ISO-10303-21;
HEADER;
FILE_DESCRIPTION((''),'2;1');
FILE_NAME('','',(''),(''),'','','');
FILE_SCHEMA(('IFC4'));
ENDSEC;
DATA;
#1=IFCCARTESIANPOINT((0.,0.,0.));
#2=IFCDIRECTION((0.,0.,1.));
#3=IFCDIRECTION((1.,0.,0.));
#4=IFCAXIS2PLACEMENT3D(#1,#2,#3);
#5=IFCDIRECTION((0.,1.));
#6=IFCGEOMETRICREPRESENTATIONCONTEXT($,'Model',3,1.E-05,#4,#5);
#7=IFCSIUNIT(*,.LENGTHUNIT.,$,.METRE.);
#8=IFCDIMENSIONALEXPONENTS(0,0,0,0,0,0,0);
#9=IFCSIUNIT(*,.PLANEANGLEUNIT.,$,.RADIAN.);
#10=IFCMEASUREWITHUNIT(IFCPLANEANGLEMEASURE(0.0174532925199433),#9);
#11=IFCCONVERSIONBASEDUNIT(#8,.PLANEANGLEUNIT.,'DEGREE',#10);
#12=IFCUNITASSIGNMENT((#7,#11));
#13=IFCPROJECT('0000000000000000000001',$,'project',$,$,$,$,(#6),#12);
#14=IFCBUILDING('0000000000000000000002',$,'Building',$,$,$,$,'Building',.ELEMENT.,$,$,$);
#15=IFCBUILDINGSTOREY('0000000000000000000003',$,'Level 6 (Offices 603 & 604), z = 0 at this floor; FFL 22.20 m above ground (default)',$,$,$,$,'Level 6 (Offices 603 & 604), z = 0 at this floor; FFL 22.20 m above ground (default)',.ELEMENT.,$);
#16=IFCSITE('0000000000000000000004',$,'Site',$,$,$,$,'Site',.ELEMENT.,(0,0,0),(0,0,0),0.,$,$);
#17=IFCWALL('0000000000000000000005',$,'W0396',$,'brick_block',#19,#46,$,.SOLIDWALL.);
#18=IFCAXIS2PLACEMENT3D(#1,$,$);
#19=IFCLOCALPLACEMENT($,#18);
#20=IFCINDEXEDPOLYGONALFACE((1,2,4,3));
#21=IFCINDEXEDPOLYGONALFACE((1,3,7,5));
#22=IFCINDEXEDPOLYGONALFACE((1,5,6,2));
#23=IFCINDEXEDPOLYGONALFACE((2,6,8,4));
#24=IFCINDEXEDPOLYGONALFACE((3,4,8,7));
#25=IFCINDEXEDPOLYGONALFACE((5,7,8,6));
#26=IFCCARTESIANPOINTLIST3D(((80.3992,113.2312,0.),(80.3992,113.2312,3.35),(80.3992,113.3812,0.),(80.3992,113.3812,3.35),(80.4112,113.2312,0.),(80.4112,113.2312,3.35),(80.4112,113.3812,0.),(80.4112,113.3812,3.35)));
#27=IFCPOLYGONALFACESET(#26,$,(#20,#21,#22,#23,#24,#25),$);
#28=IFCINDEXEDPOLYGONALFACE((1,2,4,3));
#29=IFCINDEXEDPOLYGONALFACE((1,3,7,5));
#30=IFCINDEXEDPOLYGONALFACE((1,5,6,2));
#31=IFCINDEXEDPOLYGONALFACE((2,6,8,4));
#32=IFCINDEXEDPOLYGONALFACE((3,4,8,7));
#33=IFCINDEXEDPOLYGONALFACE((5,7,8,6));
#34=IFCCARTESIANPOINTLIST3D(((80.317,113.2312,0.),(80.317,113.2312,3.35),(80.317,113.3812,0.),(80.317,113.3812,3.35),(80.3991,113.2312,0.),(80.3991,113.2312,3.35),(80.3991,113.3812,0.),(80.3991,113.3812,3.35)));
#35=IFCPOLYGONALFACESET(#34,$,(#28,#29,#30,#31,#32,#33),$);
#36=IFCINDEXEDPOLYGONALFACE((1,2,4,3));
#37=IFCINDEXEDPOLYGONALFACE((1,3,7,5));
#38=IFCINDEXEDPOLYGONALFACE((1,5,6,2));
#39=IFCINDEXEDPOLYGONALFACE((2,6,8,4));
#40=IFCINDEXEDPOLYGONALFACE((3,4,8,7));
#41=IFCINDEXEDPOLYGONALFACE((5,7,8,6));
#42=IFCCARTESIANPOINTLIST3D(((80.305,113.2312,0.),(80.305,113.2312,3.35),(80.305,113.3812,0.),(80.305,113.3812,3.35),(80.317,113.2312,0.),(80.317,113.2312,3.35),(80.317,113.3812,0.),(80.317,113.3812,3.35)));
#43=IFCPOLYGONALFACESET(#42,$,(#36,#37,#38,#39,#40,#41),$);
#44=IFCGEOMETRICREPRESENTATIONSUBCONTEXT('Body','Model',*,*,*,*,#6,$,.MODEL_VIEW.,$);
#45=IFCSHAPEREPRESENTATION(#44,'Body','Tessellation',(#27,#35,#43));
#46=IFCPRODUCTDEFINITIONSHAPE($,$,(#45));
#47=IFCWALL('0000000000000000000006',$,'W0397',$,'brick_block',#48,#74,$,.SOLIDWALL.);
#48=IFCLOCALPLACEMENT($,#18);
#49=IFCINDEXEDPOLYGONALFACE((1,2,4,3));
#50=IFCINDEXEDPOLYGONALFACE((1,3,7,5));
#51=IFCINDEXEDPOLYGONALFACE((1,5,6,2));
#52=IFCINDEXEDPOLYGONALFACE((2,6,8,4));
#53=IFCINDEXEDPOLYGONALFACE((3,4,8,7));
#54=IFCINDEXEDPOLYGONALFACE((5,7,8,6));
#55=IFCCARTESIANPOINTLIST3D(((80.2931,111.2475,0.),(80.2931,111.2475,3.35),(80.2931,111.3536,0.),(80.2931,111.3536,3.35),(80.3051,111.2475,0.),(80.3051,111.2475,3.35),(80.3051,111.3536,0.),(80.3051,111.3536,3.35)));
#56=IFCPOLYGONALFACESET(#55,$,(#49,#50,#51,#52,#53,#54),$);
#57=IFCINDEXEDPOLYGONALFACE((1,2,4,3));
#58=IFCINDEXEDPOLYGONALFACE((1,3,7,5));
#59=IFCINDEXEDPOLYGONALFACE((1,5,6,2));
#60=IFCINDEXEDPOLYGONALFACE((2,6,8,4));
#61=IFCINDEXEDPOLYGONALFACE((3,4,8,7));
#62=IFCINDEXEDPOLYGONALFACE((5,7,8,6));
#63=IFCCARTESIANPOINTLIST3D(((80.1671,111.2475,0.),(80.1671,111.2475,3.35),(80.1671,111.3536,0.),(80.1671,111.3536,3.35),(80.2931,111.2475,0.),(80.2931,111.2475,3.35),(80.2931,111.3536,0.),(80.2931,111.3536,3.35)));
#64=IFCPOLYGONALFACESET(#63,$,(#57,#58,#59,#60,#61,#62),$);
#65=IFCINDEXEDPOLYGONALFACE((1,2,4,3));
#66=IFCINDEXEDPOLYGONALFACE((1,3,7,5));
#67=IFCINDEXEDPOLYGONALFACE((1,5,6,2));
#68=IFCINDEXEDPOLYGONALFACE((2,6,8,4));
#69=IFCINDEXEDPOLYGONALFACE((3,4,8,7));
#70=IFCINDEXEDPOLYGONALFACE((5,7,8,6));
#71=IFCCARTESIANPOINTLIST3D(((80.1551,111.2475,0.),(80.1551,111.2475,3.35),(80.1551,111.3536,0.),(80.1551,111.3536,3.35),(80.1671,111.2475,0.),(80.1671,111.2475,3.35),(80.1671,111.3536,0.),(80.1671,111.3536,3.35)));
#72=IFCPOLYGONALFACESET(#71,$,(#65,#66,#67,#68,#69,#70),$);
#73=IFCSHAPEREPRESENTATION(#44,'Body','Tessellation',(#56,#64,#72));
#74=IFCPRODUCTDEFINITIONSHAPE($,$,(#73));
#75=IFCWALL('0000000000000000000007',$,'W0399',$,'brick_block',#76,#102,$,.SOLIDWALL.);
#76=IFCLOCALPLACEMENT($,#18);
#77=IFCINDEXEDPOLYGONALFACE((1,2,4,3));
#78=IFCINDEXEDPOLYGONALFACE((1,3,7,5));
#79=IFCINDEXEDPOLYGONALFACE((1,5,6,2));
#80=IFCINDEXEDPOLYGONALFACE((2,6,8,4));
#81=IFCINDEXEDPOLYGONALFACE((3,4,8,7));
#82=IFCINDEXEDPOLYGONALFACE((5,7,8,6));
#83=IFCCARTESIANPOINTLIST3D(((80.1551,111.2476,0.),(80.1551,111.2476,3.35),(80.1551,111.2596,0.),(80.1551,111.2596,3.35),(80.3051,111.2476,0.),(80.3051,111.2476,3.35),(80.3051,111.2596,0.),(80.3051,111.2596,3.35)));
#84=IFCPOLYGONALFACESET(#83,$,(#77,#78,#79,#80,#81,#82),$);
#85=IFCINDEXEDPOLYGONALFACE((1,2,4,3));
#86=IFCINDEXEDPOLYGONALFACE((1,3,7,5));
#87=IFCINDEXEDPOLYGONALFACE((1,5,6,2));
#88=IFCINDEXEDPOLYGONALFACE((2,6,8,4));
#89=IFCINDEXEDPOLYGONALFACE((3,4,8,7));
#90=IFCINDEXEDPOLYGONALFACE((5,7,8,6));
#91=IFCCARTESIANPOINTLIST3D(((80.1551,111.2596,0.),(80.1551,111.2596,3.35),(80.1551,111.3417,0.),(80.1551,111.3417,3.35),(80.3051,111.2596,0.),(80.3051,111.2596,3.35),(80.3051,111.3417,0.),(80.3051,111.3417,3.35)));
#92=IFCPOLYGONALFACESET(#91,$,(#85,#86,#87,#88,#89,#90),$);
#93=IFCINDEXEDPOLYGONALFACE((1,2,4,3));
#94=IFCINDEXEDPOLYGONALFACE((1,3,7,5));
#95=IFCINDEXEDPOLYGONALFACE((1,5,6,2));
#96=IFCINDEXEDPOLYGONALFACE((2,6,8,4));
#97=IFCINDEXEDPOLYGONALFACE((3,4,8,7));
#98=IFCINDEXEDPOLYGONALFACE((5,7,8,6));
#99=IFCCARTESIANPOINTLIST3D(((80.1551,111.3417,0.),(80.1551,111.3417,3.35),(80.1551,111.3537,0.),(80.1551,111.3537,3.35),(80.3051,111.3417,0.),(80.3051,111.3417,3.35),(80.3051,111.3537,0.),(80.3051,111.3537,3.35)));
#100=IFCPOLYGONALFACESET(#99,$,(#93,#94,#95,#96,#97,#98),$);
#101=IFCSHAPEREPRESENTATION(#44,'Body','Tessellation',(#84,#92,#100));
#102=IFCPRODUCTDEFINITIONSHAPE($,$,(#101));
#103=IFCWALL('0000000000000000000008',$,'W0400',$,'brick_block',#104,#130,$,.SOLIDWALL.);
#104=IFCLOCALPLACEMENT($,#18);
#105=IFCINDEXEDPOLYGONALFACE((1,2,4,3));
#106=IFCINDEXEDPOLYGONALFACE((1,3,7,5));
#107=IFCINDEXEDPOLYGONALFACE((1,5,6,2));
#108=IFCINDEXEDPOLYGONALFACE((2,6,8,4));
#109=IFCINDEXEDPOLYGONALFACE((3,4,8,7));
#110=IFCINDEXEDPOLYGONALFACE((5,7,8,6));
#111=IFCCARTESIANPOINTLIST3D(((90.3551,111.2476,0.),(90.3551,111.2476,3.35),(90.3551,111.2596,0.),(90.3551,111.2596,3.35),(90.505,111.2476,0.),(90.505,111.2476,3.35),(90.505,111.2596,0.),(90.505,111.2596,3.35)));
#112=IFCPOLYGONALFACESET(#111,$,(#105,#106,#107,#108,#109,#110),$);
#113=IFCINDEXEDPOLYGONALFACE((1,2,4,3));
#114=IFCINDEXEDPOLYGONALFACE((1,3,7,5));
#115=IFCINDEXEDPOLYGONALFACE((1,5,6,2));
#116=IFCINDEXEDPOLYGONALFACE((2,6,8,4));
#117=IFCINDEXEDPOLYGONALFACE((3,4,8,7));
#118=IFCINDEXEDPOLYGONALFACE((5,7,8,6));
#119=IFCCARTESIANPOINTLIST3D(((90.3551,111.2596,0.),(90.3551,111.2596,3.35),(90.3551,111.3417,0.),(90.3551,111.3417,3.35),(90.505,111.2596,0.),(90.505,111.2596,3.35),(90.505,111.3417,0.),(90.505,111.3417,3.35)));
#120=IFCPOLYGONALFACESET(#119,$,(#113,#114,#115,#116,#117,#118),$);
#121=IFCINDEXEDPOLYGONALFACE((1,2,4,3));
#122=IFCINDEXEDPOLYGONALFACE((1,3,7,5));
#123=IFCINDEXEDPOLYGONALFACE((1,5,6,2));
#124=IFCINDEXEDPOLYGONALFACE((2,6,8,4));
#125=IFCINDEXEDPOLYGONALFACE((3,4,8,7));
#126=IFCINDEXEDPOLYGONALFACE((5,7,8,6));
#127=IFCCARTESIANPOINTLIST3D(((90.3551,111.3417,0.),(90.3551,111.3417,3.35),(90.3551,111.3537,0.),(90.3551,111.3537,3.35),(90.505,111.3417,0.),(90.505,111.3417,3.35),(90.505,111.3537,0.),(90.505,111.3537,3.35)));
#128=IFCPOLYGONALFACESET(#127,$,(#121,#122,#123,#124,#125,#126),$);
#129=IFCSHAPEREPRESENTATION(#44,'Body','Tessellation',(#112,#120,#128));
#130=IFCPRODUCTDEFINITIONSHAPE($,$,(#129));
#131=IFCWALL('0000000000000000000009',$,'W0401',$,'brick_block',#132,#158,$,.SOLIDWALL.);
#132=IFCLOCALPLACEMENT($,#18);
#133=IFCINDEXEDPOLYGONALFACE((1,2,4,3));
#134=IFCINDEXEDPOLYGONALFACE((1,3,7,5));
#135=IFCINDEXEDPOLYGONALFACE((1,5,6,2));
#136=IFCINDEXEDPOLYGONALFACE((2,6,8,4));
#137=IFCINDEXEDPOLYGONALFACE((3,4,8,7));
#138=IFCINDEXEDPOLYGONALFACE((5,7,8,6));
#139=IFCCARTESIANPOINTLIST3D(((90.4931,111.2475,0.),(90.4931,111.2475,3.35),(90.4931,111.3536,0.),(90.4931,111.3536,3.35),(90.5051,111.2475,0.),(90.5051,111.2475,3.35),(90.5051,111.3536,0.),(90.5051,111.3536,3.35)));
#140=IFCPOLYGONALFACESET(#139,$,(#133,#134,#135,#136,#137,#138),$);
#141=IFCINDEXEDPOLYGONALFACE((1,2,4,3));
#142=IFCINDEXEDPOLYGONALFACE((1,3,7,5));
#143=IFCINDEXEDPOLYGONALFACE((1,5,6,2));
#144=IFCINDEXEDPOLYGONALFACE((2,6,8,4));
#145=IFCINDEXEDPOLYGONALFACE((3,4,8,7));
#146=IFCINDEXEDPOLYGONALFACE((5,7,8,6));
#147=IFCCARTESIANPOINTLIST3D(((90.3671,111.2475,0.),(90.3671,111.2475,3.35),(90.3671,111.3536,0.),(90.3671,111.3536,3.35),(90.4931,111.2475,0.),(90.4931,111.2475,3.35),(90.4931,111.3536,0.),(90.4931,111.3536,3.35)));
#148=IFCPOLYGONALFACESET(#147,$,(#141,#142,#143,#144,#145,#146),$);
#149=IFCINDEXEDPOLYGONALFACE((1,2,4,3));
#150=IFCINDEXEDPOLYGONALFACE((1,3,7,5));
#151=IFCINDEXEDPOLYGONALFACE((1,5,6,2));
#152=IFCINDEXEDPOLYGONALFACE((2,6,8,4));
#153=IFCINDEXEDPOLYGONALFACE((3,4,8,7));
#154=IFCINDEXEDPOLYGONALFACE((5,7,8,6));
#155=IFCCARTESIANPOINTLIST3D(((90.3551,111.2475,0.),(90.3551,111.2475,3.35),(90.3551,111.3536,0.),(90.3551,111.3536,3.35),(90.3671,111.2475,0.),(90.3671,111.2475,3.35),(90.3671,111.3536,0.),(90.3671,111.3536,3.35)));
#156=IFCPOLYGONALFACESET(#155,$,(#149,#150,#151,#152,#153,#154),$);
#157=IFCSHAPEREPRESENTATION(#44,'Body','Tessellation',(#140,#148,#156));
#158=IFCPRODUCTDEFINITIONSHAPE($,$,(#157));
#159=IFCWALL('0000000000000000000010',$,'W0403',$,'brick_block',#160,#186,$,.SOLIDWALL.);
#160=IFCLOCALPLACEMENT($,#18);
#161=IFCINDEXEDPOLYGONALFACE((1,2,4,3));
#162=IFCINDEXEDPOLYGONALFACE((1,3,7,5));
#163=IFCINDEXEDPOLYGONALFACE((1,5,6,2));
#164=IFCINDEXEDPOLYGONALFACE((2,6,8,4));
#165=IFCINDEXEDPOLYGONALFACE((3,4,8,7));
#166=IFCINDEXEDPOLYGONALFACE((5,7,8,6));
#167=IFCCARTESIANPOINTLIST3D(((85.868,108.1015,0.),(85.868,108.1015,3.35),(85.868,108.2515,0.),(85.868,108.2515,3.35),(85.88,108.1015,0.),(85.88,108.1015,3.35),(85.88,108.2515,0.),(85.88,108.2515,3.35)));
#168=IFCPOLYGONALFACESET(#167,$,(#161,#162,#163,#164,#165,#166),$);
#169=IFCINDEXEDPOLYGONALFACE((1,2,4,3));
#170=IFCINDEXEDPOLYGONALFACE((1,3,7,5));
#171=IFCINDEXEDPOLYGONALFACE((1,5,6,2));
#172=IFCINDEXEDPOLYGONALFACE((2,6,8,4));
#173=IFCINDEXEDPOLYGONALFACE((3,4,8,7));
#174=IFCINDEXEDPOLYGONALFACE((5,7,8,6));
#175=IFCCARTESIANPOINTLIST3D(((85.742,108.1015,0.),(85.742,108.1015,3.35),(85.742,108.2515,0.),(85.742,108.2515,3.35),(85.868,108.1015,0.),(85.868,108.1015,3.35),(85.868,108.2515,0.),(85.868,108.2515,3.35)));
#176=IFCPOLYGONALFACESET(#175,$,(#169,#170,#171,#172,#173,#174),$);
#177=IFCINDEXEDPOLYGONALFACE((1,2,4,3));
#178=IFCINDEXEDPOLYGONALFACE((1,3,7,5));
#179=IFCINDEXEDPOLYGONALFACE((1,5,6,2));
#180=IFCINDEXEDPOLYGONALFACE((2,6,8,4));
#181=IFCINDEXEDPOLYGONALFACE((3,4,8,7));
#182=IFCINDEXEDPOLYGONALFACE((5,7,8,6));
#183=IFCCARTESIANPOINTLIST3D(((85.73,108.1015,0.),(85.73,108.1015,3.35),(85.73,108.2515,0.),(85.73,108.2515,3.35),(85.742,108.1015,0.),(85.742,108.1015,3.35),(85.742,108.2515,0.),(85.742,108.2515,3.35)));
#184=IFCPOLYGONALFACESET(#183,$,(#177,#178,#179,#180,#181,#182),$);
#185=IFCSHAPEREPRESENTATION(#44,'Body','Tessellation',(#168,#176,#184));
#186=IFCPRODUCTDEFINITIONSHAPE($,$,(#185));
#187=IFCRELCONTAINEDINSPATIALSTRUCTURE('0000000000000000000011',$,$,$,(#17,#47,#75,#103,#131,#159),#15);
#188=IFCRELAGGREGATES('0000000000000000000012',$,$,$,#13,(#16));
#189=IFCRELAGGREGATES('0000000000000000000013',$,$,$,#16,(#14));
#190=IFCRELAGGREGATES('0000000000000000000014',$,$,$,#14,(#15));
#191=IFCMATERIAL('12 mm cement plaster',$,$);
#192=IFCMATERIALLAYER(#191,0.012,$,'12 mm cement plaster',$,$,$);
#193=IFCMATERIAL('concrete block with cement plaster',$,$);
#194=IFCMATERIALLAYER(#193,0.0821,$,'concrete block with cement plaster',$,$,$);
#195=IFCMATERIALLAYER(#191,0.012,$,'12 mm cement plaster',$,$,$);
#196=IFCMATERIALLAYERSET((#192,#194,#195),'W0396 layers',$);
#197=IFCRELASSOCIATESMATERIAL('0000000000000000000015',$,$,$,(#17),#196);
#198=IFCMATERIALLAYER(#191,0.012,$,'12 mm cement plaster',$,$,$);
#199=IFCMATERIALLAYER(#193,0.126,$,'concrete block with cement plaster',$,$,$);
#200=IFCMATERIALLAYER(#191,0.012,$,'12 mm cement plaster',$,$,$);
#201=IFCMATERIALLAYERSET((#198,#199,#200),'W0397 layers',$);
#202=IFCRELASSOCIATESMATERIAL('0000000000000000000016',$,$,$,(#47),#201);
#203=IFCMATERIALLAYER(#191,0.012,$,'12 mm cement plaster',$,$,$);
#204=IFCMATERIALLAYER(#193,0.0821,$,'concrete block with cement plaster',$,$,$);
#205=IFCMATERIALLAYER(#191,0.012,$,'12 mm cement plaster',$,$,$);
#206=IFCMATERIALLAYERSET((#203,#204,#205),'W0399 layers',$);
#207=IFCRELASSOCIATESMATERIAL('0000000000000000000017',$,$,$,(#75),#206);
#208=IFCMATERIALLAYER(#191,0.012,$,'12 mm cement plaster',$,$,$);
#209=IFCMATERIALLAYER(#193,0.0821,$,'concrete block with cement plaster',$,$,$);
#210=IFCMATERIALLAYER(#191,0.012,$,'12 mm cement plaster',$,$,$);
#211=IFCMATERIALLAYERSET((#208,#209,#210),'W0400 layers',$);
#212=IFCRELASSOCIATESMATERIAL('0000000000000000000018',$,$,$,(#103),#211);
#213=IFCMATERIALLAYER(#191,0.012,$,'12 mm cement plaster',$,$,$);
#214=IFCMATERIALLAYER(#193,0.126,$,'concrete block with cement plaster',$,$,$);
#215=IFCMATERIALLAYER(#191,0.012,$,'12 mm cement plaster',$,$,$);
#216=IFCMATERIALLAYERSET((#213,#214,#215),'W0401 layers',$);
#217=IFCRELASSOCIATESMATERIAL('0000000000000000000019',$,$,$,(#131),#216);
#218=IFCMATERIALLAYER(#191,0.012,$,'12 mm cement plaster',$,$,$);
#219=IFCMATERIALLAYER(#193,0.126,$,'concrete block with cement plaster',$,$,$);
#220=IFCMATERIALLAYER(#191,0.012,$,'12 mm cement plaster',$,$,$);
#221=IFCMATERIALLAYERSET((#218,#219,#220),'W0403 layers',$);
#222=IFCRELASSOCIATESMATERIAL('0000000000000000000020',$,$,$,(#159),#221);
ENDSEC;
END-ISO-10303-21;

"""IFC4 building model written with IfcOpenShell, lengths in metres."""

from ifc_helpers import new_model, entity, si_unit, converted_unit, direction, frame, frame_2d, origin_with_axes, place, context, subcontext, project, spatial, rectangle, extrude, material, layer, layer_set, layer_usage, element, save


model = new_model("IFC4")

# Units and contexts
model_context = context("Model", 3, precision=1e-05, world=origin_with_axes(), true_north=direction((0.0, 1.0)))
body_context = subcontext(model_context, "Body", "Model", "MODEL_VIEW")
ifc_project = project(units=[si_unit("LENGTHUNIT", "METRE"), converted_unit("PLANEANGLEUNIT", "DEGREE", entity("IfcPlaneAngleMeasure", 0.0174532925199433), si_unit("PLANEANGLEUNIT", "RADIAN"), dimensions=[0, 0, 0, 0, 0, 0, 0])], contexts=[model_context])

# Site, building, storey
site = spatial("IfcSite", under=ifc_project, Name="Site", LongName="Site", CompositionType="ELEMENT", RefLatitude=(0, 0, 0), RefLongitude=(0, 0, 0), RefElevation=0.0)
building = spatial("IfcBuilding", under=site, Name="Building", LongName="Building", CompositionType="ELEMENT")
storey = spatial("IfcBuildingStorey", under=building, Name="Level 6 (Offices 603 & 604), z = 0 at this floor; FFL 22.20 m above ground (default)", LongName="Level 6 (Offices 603 & 604), z = 0 at this floor; FFL 22.20 m above ground (default)", CompositionType="ELEMENT")

# Shared definitions
placement = place(None, origin_with_axes())

# Walls
ifc_material_1 = material(Name="12 mm cement plaster")
ifc_material_2 = material(Name="concrete block with cement plaster")
ifc_layer_1 = layer(ifc_material_1, 0.012, Name="12 mm cement plaster")
ifc_layer_2 = layer(ifc_material_2, 0.0821, Name="concrete block with cement plaster")
ifc_layer_3 = layer(ifc_material_1, 0.012, Name="12 mm cement plaster")
ifc_layer_set_1 = layer_set([ifc_layer_1, ifc_layer_2, ifc_layer_3], Name="W0396 layers")
ifc_layer_usage_1 = layer_usage(ifc_layer_set_1, "AXIS2", "POSITIVE", -0.053)
element("IfcWall", 1, at=placement, inside=storey, material=ifc_layer_usage_1, Name="W0396", ObjectType="brick_block", PredefinedType="SOLIDWALL", context=body_context, shape_type="SweptSolid", body=[
    extrude(rectangle(XDim=0.15, YDim=0.012, at=frame_2d((0.0, 0.0), x_axis=(0.0, 1.0))), frame((80.4052, 113.3062, 0.0), z_axis=(0.0, 0.0, 1.0), x_axis=(1.0, 0.0, 0.0)), (0.0, 0.0, 1.0), 3.35),
    extrude(rectangle(XDim=0.15, YDim=0.0821, at=frame_2d((-0.0471, 0.0), x_axis=(0.0, 1.0))), frame((80.4052, 113.3062, 0.0), z_axis=(0.0, 0.0, 1.0), x_axis=(1.0, 0.0, 0.0)), (0.0, 0.0, 1.0), 3.35),
    extrude(rectangle(XDim=0.15, YDim=0.012, at=frame_2d((-0.0941, 0.0), x_axis=(0.0, 1.0))), frame((80.4052, 113.3062, 0.0), z_axis=(0.0, 0.0, 1.0), x_axis=(1.0, 0.0, 0.0)), (0.0, 0.0, 1.0), 3.35),
])
ifc_layer_4 = layer(ifc_material_1, 0.012, Name="12 mm cement plaster")
ifc_layer_5 = layer(ifc_material_2, 0.126, Name="concrete block with cement plaster")
ifc_layer_6 = layer(ifc_material_1, 0.012, Name="12 mm cement plaster")
ifc_layer_set_2 = layer_set([ifc_layer_4, ifc_layer_5, ifc_layer_6], Name="W0397 layers")
ifc_layer_usage_2 = layer_usage(ifc_layer_set_2, "AXIS2", "POSITIVE", -0.075)
element("IfcWall", 2, at=placement, inside=storey, material=ifc_layer_usage_2, Name="W0397", ObjectType="brick_block", PredefinedType="SOLIDWALL", context=body_context, shape_type="SweptSolid", body=[
    extrude(rectangle(XDim=0.1061, YDim=0.012, at=frame_2d((0.0, 0.0), x_axis=(0.0, 1.0))), frame((80.2991, 111.3006, 0.0), z_axis=(0.0, 0.0, 1.0), x_axis=(1.0, 0.0, 0.0)), (0.0, 0.0, 1.0), 3.35),
    extrude(rectangle(XDim=0.1061, YDim=0.126, at=frame_2d((-0.069, 0.0), x_axis=(0.0, 1.0))), frame((80.2991, 111.3006, 0.0), z_axis=(0.0, 0.0, 1.0), x_axis=(1.0, 0.0, 0.0)), (0.0, 0.0, 1.0), 3.35),
    extrude(rectangle(XDim=0.1061, YDim=0.012, at=frame_2d((-0.138, 0.0), x_axis=(0.0, 1.0))), frame((80.2991, 111.3006, 0.0), z_axis=(0.0, 0.0, 1.0), x_axis=(1.0, 0.0, 0.0)), (0.0, 0.0, 1.0), 3.35),
])
ifc_layer_7 = layer(ifc_material_1, 0.012, Name="12 mm cement plaster")
ifc_layer_8 = layer(ifc_material_2, 0.0821, Name="concrete block with cement plaster")
ifc_layer_9 = layer(ifc_material_1, 0.012, Name="12 mm cement plaster")
ifc_layer_set_3 = layer_set([ifc_layer_7, ifc_layer_8, ifc_layer_9], Name="W0399 layers")
ifc_layer_usage_3 = layer_usage(ifc_layer_set_3, "AXIS2", "POSITIVE", -0.053)
element("IfcWall", 3, at=placement, inside=storey, material=ifc_layer_usage_3, Name="W0399", ObjectType="brick_block", PredefinedType="SOLIDWALL", context=body_context, shape_type="SweptSolid", body=[
    extrude(rectangle(XDim=0.15, YDim=0.012, at=frame_2d((0.0, 0.0), x_axis=(1.0, 0.0))), frame((80.2301, 111.2536, 0.0), z_axis=(0.0, 0.0, 1.0), x_axis=(1.0, 0.0, 0.0)), (0.0, 0.0, 1.0), 3.35),
    extrude(rectangle(XDim=0.15, YDim=0.0821, at=frame_2d((0.0, 0.0471), x_axis=(1.0, 0.0))), frame((80.2301, 111.2536, 0.0), z_axis=(0.0, 0.0, 1.0), x_axis=(1.0, 0.0, 0.0)), (0.0, 0.0, 1.0), 3.35),
    extrude(rectangle(XDim=0.15, YDim=0.012, at=frame_2d((0.0, 0.0941), x_axis=(1.0, 0.0))), frame((80.2301, 111.2536, 0.0), z_axis=(0.0, 0.0, 1.0), x_axis=(1.0, 0.0, 0.0)), (0.0, 0.0, 1.0), 3.35),
])
ifc_layer_10 = layer(ifc_material_1, 0.012, Name="12 mm cement plaster")
ifc_layer_11 = layer(ifc_material_2, 0.0821, Name="concrete block with cement plaster")
ifc_layer_12 = layer(ifc_material_1, 0.012, Name="12 mm cement plaster")
ifc_layer_set_4 = layer_set([ifc_layer_10, ifc_layer_11, ifc_layer_12], Name="W0400 layers")
ifc_layer_usage_4 = layer_usage(ifc_layer_set_4, "AXIS2", "POSITIVE", -0.053)
element("IfcWall", 4, at=placement, inside=storey, material=ifc_layer_usage_4, Name="W0400", ObjectType="brick_block", PredefinedType="SOLIDWALL", context=body_context, shape_type="SweptSolid", body=[
    extrude(rectangle(XDim=0.1499, YDim=0.012, at=frame_2d((0.0, 0.0), x_axis=(1.0, 0.0))), frame((90.43, 111.2536, 0.0), z_axis=(0.0, 0.0, 1.0), x_axis=(1.0, 0.0, 0.0)), (0.0, 0.0, 1.0), 3.35),
    extrude(rectangle(XDim=0.1499, YDim=0.0821, at=frame_2d((0.0, 0.0471), x_axis=(1.0, 0.0))), frame((90.43, 111.2536, 0.0), z_axis=(0.0, 0.0, 1.0), x_axis=(1.0, 0.0, 0.0)), (0.0, 0.0, 1.0), 3.35),
    extrude(rectangle(XDim=0.1499, YDim=0.012, at=frame_2d((0.0, 0.0941), x_axis=(1.0, 0.0))), frame((90.43, 111.2536, 0.0), z_axis=(0.0, 0.0, 1.0), x_axis=(1.0, 0.0, 0.0)), (0.0, 0.0, 1.0), 3.35),
])
ifc_layer_13 = layer(ifc_material_1, 0.012, Name="12 mm cement plaster")
ifc_layer_14 = layer(ifc_material_2, 0.126, Name="concrete block with cement plaster")
ifc_layer_15 = layer(ifc_material_1, 0.012, Name="12 mm cement plaster")
ifc_layer_set_5 = layer_set([ifc_layer_13, ifc_layer_14, ifc_layer_15], Name="W0401 layers")
ifc_layer_usage_5 = layer_usage(ifc_layer_set_5, "AXIS2", "POSITIVE", -0.075)
element("IfcWall", 5, at=placement, inside=storey, material=ifc_layer_usage_5, Name="W0401", ObjectType="brick_block", PredefinedType="SOLIDWALL", context=body_context, shape_type="SweptSolid", body=[
    extrude(rectangle(XDim=0.1061, YDim=0.012, at=frame_2d((0.0, 0.0), x_axis=(0.0, 1.0))), frame((90.4991, 111.3006, 0.0), z_axis=(0.0, 0.0, 1.0), x_axis=(1.0, 0.0, 0.0)), (0.0, 0.0, 1.0), 3.35),
    extrude(rectangle(XDim=0.1061, YDim=0.126, at=frame_2d((-0.069, 0.0), x_axis=(0.0, 1.0))), frame((90.4991, 111.3006, 0.0), z_axis=(0.0, 0.0, 1.0), x_axis=(1.0, 0.0, 0.0)), (0.0, 0.0, 1.0), 3.35),
    extrude(rectangle(XDim=0.1061, YDim=0.012, at=frame_2d((-0.138, 0.0), x_axis=(0.0, 1.0))), frame((90.4991, 111.3006, 0.0), z_axis=(0.0, 0.0, 1.0), x_axis=(1.0, 0.0, 0.0)), (0.0, 0.0, 1.0), 3.35),
])
ifc_layer_16 = layer(ifc_material_1, 0.012, Name="12 mm cement plaster")
ifc_layer_17 = layer(ifc_material_2, 0.126, Name="concrete block with cement plaster")
ifc_layer_18 = layer(ifc_material_1, 0.012, Name="12 mm cement plaster")
ifc_layer_set_6 = layer_set([ifc_layer_16, ifc_layer_17, ifc_layer_18], Name="W0403 layers")
ifc_layer_usage_6 = layer_usage(ifc_layer_set_6, "AXIS2", "POSITIVE", -0.075)
element("IfcWall", 6, at=placement, inside=storey, material=ifc_layer_usage_6, Name="W0403", ObjectType="brick_block", PredefinedType="SOLIDWALL", context=body_context, shape_type="SweptSolid", body=[
    extrude(rectangle(XDim=0.15, YDim=0.012, at=frame_2d((0.0, 0.0), x_axis=(0.0, 1.0))), frame((85.874, 108.1765, 0.0), z_axis=(0.0, 0.0, 1.0), x_axis=(1.0, 0.0, 0.0)), (0.0, 0.0, 1.0), 3.35),
    extrude(rectangle(XDim=0.15, YDim=0.126, at=frame_2d((-0.069, 0.0), x_axis=(0.0, 1.0))), frame((85.874, 108.1765, 0.0), z_axis=(0.0, 0.0, 1.0), x_axis=(1.0, 0.0, 0.0)), (0.0, 0.0, 1.0), 3.35),
    extrude(rectangle(XDim=0.15, YDim=0.012, at=frame_2d((-0.138, 0.0), x_axis=(0.0, 1.0))), frame((85.874, 108.1765, 0.0), z_axis=(0.0, 0.0, 1.0), x_axis=(1.0, 0.0, 0.0)), (0.0, 0.0, 1.0), 3.35),
])

save(model, "model.ifc")
